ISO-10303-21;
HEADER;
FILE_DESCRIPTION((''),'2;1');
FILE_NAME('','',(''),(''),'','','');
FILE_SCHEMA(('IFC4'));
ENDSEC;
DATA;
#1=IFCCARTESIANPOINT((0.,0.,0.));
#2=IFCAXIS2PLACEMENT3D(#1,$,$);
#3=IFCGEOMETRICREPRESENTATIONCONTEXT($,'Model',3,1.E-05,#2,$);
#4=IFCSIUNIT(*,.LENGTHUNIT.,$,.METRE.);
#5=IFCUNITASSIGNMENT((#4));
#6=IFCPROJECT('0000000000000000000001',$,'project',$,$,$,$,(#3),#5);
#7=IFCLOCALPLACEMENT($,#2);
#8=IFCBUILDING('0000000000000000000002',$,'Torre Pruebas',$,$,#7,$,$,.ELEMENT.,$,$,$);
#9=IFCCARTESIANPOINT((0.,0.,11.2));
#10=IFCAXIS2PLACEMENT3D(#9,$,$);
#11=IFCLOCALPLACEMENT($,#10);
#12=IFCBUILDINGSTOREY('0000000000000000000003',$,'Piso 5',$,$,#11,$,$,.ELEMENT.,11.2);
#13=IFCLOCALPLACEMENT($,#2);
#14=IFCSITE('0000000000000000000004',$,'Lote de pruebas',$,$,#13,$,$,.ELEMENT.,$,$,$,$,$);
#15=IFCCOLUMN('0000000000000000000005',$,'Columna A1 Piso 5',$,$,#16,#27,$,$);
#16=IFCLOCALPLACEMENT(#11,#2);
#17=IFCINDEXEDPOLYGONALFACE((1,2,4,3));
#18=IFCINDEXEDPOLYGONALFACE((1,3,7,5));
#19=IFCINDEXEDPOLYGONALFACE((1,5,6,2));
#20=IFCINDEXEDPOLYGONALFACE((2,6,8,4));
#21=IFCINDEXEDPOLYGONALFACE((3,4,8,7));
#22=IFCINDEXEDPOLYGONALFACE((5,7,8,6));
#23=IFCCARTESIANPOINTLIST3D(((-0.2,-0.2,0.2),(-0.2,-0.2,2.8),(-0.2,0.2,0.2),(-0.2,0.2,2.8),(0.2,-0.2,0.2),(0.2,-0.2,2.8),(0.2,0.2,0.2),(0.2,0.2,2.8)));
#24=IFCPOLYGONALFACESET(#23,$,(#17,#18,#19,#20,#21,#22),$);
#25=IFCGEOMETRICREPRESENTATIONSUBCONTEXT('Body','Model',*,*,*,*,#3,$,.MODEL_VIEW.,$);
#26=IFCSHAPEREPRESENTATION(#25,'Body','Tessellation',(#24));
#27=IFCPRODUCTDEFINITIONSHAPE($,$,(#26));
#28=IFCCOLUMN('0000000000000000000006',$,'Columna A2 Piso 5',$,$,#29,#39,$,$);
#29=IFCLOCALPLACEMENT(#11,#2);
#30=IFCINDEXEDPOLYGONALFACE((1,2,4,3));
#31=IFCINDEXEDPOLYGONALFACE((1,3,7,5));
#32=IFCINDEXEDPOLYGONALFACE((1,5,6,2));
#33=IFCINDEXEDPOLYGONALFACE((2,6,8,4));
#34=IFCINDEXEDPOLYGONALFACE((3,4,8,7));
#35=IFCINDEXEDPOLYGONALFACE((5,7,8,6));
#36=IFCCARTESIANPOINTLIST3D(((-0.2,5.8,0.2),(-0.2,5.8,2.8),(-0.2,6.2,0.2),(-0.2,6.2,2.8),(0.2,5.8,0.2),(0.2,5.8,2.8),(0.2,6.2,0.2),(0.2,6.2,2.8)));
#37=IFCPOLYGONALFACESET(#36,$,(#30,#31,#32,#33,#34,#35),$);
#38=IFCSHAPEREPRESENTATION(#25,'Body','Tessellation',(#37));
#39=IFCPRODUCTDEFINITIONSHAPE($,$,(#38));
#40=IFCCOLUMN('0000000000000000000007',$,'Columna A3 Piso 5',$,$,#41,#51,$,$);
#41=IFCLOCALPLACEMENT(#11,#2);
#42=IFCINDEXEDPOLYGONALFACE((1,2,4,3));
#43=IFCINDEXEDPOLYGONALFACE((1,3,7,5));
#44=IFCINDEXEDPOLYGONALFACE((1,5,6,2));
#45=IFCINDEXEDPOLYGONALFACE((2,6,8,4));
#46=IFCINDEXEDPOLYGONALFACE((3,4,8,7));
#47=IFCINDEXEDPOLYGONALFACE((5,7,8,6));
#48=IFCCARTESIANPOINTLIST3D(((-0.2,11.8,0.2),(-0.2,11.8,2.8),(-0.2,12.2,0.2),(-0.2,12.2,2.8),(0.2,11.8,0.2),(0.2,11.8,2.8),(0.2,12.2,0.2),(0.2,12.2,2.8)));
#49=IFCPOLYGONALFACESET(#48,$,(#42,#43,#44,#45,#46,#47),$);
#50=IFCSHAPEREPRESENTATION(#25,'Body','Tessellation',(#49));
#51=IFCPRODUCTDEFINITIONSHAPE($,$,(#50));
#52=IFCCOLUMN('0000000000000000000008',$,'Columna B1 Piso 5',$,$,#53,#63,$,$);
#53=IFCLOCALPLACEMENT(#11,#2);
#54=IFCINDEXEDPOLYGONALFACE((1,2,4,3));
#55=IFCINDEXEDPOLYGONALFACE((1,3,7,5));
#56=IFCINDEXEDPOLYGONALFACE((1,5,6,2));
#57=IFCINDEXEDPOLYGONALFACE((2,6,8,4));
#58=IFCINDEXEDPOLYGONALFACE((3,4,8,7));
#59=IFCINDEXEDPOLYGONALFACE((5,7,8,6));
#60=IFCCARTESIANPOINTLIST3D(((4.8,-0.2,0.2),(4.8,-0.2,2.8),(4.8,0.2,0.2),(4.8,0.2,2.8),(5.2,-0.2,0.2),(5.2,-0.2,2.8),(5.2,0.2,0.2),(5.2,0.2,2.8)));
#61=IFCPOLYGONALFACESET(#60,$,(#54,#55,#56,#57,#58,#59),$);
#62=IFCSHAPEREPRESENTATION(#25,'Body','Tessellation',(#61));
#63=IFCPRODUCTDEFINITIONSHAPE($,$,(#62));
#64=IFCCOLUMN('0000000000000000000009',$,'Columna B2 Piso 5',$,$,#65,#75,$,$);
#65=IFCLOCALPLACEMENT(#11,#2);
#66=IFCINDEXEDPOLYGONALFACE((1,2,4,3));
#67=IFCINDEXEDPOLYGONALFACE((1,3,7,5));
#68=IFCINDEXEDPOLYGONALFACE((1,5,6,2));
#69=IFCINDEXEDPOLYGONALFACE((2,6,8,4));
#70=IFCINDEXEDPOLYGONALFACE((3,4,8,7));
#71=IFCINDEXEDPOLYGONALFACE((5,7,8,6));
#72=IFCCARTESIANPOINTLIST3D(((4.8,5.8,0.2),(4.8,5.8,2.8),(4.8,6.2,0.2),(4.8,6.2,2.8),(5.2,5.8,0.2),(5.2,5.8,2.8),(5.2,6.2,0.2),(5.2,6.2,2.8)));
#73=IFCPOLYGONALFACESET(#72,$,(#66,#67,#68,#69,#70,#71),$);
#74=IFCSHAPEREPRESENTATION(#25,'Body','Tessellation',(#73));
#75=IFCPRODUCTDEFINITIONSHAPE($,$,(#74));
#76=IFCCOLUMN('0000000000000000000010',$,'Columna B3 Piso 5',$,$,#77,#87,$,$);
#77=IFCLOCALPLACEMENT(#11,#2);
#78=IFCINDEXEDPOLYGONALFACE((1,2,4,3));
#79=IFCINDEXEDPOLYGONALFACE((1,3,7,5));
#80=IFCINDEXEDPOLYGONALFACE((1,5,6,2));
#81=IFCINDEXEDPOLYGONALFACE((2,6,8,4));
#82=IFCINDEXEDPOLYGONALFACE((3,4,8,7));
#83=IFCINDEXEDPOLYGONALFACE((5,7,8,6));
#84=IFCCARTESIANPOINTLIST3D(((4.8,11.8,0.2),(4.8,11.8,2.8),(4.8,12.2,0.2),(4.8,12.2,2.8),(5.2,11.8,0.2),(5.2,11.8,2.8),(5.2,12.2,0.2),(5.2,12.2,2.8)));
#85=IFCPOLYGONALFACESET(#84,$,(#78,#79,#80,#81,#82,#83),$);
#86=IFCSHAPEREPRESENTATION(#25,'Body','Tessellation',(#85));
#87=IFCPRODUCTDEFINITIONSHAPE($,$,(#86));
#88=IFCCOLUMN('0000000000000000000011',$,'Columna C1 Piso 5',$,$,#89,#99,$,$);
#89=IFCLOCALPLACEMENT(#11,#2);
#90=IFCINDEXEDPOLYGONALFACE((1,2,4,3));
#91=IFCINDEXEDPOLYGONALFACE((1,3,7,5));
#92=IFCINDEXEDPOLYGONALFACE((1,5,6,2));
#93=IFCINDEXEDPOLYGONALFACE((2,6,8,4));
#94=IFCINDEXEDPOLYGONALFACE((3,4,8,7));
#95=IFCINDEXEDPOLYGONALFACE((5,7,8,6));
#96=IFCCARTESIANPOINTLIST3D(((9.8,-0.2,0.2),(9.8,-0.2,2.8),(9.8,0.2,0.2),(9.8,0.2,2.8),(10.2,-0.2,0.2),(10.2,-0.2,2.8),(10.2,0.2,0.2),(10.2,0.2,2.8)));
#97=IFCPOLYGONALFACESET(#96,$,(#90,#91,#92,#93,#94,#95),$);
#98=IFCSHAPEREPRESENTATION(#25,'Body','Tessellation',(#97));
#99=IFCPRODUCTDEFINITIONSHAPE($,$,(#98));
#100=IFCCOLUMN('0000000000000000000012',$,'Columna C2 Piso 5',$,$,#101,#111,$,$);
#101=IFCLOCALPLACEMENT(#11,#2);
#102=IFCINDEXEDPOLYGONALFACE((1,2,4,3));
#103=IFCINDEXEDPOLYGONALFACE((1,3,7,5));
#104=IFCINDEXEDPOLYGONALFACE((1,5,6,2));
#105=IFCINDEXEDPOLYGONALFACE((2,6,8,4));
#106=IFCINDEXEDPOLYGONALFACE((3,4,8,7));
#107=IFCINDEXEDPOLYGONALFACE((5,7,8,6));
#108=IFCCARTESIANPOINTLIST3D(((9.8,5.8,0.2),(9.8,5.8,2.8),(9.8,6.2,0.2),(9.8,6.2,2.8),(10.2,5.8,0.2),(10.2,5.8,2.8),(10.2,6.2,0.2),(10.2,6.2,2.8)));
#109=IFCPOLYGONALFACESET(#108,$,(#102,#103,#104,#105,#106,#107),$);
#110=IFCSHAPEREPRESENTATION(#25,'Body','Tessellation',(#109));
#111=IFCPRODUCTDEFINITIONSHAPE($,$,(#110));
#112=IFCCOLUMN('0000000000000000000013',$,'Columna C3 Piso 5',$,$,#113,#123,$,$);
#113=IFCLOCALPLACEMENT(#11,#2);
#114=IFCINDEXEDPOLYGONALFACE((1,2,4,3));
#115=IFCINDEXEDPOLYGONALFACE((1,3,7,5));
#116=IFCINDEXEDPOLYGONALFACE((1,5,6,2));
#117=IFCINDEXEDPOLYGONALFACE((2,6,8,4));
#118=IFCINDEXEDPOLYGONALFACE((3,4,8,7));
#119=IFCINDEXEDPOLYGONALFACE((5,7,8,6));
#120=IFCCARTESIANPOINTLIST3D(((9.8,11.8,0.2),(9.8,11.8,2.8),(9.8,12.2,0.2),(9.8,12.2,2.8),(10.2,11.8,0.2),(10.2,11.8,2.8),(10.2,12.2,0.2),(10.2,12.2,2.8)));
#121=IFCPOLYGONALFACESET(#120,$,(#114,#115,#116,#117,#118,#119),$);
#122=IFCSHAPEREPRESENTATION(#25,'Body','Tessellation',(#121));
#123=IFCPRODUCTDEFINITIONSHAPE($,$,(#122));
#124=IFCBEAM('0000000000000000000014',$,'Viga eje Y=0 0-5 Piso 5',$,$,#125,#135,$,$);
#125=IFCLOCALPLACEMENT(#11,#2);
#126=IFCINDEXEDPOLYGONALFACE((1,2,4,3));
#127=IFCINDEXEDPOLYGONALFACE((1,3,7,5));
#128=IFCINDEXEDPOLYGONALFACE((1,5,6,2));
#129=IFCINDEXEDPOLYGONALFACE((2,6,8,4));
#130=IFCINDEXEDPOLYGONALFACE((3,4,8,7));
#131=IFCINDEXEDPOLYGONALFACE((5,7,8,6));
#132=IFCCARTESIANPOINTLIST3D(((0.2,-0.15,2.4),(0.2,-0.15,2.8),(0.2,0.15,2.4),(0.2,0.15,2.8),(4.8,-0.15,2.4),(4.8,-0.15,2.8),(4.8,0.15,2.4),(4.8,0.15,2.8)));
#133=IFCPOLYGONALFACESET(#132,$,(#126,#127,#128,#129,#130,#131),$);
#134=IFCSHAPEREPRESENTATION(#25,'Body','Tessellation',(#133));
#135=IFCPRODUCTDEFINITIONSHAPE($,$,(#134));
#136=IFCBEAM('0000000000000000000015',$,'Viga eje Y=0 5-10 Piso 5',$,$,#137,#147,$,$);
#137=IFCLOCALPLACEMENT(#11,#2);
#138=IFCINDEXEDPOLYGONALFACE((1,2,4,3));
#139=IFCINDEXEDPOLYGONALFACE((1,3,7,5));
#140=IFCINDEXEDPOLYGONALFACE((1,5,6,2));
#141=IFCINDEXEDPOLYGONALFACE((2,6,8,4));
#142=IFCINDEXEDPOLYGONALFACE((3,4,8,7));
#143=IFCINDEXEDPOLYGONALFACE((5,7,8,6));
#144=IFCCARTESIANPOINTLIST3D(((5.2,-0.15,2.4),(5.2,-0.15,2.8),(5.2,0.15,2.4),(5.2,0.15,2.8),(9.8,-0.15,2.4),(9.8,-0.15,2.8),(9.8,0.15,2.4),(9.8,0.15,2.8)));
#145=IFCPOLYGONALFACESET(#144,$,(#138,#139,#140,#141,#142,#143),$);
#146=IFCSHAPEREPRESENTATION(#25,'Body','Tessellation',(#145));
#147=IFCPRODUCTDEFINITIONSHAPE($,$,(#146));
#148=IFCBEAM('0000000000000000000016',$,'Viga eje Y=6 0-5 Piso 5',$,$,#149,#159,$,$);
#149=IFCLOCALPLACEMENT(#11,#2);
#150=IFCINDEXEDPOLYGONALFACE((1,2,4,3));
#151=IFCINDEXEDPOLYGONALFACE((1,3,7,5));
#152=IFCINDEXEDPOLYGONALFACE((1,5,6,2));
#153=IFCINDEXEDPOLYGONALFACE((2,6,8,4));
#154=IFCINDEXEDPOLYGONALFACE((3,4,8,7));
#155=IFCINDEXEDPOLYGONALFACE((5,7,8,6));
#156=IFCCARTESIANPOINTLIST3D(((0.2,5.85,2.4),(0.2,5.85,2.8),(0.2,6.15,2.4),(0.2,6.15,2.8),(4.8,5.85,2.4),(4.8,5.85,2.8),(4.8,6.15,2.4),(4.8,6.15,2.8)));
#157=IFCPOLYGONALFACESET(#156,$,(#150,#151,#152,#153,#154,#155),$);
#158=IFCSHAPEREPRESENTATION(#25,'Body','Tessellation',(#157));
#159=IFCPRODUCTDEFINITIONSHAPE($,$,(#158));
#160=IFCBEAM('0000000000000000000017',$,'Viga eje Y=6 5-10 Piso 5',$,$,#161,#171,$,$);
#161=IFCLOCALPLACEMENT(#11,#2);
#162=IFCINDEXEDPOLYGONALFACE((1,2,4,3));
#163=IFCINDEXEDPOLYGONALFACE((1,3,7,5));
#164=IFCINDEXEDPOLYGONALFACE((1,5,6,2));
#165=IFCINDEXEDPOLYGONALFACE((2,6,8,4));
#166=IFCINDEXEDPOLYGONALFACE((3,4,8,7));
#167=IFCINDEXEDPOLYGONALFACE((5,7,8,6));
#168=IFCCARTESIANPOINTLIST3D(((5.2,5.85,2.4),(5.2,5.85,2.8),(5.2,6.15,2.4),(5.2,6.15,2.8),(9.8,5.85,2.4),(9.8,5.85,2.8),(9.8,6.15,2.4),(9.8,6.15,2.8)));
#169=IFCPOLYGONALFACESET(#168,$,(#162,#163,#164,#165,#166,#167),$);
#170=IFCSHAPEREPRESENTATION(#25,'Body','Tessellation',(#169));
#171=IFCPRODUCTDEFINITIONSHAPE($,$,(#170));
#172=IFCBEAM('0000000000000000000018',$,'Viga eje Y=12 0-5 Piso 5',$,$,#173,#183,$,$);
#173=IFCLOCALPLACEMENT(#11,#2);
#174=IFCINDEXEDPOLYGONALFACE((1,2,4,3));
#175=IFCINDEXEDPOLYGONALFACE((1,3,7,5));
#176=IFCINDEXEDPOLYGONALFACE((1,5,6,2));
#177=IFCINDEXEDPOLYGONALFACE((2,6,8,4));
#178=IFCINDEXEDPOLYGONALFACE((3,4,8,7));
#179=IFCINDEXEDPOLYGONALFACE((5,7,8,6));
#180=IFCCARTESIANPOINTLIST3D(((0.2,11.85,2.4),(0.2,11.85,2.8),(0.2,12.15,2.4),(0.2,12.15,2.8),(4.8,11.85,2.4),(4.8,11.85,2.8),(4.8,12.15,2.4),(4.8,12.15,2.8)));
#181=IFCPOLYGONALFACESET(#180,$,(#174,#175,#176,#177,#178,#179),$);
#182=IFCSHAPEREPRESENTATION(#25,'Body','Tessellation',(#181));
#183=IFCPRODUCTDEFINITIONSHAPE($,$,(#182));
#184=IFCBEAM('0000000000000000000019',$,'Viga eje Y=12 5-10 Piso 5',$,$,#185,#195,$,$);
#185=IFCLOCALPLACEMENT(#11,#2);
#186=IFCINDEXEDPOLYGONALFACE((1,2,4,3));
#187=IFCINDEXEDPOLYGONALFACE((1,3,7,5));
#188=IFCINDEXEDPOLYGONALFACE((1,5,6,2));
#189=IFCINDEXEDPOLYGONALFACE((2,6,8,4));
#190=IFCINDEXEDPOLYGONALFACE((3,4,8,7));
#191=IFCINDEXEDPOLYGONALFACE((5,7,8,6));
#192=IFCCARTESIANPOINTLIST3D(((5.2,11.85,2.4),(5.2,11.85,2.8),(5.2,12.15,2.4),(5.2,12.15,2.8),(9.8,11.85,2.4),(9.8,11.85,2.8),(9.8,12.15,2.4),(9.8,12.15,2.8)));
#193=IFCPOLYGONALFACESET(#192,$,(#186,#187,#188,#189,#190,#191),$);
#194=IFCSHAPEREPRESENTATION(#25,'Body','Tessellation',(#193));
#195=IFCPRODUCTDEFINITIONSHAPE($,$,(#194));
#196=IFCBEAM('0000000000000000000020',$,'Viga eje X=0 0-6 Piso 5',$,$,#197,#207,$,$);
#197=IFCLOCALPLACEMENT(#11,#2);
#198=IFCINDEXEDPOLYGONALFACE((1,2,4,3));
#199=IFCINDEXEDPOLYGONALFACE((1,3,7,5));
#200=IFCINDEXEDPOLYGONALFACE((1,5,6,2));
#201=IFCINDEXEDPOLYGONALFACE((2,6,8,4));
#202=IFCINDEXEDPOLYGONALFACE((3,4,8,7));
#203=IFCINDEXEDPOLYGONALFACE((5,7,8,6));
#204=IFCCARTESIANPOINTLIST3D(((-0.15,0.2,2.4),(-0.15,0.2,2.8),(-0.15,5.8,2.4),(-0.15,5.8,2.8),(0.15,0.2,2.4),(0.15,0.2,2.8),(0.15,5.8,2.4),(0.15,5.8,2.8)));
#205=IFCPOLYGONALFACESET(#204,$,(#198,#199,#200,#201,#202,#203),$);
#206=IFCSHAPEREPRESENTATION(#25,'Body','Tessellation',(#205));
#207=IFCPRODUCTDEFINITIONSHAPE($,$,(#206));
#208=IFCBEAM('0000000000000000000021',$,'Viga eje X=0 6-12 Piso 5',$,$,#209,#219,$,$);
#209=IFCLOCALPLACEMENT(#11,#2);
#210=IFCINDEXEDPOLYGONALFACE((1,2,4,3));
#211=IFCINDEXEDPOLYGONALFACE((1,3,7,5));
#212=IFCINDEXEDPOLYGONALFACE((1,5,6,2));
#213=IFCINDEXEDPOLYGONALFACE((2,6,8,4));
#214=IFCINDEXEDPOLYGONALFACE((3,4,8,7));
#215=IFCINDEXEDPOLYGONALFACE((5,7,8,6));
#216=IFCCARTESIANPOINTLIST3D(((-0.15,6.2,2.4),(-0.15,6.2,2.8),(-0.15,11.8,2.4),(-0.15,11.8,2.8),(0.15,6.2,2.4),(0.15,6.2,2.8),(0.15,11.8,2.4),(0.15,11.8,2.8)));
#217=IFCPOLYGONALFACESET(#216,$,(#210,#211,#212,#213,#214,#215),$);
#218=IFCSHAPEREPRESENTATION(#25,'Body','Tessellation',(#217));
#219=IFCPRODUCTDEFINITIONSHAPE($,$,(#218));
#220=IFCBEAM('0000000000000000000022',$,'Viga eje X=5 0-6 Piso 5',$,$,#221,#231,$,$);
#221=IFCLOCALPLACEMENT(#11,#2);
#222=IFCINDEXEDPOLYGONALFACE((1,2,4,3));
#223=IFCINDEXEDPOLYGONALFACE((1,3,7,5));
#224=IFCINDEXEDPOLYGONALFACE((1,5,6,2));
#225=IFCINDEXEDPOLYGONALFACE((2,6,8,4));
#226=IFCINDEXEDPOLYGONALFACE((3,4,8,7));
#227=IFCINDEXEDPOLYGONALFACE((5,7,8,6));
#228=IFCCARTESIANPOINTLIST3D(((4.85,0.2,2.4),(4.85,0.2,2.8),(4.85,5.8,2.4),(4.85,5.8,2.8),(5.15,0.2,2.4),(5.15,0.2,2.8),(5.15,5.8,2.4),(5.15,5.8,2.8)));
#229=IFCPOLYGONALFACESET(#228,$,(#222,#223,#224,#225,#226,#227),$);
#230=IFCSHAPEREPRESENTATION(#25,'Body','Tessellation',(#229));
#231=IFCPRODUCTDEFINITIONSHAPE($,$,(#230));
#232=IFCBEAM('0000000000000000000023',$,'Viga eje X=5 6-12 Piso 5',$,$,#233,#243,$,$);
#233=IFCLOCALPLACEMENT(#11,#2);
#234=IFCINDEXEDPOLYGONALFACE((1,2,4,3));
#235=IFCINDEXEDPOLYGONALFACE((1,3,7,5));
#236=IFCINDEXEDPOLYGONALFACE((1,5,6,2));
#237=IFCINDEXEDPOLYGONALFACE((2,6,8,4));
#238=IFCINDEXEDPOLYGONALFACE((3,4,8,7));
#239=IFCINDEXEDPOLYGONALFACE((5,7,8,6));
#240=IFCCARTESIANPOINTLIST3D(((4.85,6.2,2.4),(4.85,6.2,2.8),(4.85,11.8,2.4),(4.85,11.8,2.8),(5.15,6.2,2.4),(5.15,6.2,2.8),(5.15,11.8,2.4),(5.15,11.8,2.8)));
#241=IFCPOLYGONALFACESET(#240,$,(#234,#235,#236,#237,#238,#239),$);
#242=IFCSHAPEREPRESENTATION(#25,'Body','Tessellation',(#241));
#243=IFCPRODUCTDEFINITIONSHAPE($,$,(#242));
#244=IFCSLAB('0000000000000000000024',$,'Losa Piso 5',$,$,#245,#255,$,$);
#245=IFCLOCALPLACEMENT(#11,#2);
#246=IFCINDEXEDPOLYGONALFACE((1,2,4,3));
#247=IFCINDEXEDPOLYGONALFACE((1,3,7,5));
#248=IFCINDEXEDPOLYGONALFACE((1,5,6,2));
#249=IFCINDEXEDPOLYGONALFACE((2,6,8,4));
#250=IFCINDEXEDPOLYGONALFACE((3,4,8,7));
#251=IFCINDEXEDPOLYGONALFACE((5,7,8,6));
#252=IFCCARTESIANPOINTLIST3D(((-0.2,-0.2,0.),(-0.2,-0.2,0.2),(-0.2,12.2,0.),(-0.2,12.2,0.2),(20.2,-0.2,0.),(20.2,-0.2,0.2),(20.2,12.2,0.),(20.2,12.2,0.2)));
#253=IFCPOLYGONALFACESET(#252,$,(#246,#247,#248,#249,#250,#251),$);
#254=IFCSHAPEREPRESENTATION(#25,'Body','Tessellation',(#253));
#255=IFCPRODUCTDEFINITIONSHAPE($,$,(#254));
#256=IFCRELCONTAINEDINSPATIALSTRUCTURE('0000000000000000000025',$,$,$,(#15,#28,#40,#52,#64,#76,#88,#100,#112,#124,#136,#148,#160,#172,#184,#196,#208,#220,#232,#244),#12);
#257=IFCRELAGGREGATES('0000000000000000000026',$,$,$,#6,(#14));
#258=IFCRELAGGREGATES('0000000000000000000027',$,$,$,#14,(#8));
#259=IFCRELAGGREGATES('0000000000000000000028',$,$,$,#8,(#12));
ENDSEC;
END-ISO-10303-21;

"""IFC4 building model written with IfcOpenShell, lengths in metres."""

from ifc_helpers import new_model, si_unit, frame, origin, origin_2d, place, context, subcontext, project, spatial, rectangle, extrude, element, save


model = new_model("IFC4")

# Units and contexts
model_context = context("Model", 3, precision=1e-05, world=origin())
body_context = subcontext(model_context, "Body", "Model", "MODEL_VIEW")
ifc_project = project(units=[si_unit("LENGTHUNIT", "METRE")], contexts=[model_context])

# Site, building, storey
site_placement = place(None, origin())
site = spatial("IfcSite", under=ifc_project, at=site_placement, Name="Lote de pruebas", CompositionType="ELEMENT")
building_placement = place(None, origin())
building = spatial("IfcBuilding", under=site, at=building_placement, Name="Torre Pruebas", CompositionType="ELEMENT")
storey_placement = place(None, frame((0.0, 0.0, 11.2)))
storey = spatial("IfcBuildingStorey", under=building, at=storey_placement, Name="Piso 5", CompositionType="ELEMENT", Elevation=11.2)

# Columns
for number, where, name in (
    (1, (0.0, 0.0, 11.4), "Columna A1 Piso 5"),
    (2, (0.0, 6.0, 11.4), "Columna A2 Piso 5"),
    (3, (0.0, 12.0, 11.4), "Columna A3 Piso 5"),
    (4, (5.0, 0.0, 11.4), "Columna B1 Piso 5"),
    (5, (5.0, 6.0, 11.4), "Columna B2 Piso 5"),
    (6, (5.0, 12.0, 11.4), "Columna B3 Piso 5"),
    (7, (10.0, 0.0, 11.4), "Columna C1 Piso 5"),
    (8, (10.0, 6.0, 11.4), "Columna C2 Piso 5"),
    (9, (10.0, 12.0, 11.4), "Columna C3 Piso 5"),
):
    element("IfcColumn", number, at=place(None, frame(where)), inside=storey, Name=name, context=body_context, shape_type="SweptSolid", body=[
        extrude(rectangle(XDim=0.4, YDim=0.4, at=origin_2d()), origin(), (0.0, 0.0, 1.0), 2.6),
    ])

# Beams
for number, where, name in (
    (10, (2.5, 0.0, 13.6), "Viga eje Y=0 0-5 Piso 5"),
    (11, (7.5, 0.0, 13.6), "Viga eje Y=0 5-10 Piso 5"),
    (12, (2.5, 6.0, 13.6), "Viga eje Y=6 0-5 Piso 5"),
    (13, (7.5, 6.0, 13.6), "Viga eje Y=6 5-10 Piso 5"),
    (14, (2.5, 12.0, 13.6), "Viga eje Y=12 0-5 Piso 5"),
    (15, (7.5, 12.0, 13.6), "Viga eje Y=12 5-10 Piso 5"),
):
    element("IfcBeam", number, at=place(None, frame(where)), inside=storey, Name=name, context=body_context, shape_type="SweptSolid", body=[
        extrude(rectangle(XDim=4.6, YDim=0.3, at=origin_2d()), origin(), (0.0, 0.0, 1.0), 0.4),
    ])
for number, where, name in (
    (16, (0.0, 3.0, 13.6), "Viga eje X=0 0-6 Piso 5"),
    (17, (0.0, 9.0, 13.6), "Viga eje X=0 6-12 Piso 5"),
    (18, (5.0, 3.0, 13.6), "Viga eje X=5 0-6 Piso 5"),
    (19, (5.0, 9.0, 13.6), "Viga eje X=5 6-12 Piso 5"),
):
    element("IfcBeam", number, at=place(None, frame(where)), inside=storey, Name=name, context=body_context, shape_type="SweptSolid", body=[
        extrude(rectangle(XDim=0.3, YDim=5.6, at=origin_2d()), origin(), (0.0, 0.0, 1.0), 0.4),
    ])

# Slab
slab_placement = place(None, frame((10.0, 6.0, 11.2)))
element("IfcSlab", 20, at=slab_placement, inside=storey, Name="Losa Piso 5", context=body_context, shape_type="SweptSolid", body=[
    extrude(rectangle(XDim=20.4, YDim=12.4, at=origin_2d()), origin(), (0.0, 0.0, 1.0), 0.2),
])

save(model, "model.ifc")
